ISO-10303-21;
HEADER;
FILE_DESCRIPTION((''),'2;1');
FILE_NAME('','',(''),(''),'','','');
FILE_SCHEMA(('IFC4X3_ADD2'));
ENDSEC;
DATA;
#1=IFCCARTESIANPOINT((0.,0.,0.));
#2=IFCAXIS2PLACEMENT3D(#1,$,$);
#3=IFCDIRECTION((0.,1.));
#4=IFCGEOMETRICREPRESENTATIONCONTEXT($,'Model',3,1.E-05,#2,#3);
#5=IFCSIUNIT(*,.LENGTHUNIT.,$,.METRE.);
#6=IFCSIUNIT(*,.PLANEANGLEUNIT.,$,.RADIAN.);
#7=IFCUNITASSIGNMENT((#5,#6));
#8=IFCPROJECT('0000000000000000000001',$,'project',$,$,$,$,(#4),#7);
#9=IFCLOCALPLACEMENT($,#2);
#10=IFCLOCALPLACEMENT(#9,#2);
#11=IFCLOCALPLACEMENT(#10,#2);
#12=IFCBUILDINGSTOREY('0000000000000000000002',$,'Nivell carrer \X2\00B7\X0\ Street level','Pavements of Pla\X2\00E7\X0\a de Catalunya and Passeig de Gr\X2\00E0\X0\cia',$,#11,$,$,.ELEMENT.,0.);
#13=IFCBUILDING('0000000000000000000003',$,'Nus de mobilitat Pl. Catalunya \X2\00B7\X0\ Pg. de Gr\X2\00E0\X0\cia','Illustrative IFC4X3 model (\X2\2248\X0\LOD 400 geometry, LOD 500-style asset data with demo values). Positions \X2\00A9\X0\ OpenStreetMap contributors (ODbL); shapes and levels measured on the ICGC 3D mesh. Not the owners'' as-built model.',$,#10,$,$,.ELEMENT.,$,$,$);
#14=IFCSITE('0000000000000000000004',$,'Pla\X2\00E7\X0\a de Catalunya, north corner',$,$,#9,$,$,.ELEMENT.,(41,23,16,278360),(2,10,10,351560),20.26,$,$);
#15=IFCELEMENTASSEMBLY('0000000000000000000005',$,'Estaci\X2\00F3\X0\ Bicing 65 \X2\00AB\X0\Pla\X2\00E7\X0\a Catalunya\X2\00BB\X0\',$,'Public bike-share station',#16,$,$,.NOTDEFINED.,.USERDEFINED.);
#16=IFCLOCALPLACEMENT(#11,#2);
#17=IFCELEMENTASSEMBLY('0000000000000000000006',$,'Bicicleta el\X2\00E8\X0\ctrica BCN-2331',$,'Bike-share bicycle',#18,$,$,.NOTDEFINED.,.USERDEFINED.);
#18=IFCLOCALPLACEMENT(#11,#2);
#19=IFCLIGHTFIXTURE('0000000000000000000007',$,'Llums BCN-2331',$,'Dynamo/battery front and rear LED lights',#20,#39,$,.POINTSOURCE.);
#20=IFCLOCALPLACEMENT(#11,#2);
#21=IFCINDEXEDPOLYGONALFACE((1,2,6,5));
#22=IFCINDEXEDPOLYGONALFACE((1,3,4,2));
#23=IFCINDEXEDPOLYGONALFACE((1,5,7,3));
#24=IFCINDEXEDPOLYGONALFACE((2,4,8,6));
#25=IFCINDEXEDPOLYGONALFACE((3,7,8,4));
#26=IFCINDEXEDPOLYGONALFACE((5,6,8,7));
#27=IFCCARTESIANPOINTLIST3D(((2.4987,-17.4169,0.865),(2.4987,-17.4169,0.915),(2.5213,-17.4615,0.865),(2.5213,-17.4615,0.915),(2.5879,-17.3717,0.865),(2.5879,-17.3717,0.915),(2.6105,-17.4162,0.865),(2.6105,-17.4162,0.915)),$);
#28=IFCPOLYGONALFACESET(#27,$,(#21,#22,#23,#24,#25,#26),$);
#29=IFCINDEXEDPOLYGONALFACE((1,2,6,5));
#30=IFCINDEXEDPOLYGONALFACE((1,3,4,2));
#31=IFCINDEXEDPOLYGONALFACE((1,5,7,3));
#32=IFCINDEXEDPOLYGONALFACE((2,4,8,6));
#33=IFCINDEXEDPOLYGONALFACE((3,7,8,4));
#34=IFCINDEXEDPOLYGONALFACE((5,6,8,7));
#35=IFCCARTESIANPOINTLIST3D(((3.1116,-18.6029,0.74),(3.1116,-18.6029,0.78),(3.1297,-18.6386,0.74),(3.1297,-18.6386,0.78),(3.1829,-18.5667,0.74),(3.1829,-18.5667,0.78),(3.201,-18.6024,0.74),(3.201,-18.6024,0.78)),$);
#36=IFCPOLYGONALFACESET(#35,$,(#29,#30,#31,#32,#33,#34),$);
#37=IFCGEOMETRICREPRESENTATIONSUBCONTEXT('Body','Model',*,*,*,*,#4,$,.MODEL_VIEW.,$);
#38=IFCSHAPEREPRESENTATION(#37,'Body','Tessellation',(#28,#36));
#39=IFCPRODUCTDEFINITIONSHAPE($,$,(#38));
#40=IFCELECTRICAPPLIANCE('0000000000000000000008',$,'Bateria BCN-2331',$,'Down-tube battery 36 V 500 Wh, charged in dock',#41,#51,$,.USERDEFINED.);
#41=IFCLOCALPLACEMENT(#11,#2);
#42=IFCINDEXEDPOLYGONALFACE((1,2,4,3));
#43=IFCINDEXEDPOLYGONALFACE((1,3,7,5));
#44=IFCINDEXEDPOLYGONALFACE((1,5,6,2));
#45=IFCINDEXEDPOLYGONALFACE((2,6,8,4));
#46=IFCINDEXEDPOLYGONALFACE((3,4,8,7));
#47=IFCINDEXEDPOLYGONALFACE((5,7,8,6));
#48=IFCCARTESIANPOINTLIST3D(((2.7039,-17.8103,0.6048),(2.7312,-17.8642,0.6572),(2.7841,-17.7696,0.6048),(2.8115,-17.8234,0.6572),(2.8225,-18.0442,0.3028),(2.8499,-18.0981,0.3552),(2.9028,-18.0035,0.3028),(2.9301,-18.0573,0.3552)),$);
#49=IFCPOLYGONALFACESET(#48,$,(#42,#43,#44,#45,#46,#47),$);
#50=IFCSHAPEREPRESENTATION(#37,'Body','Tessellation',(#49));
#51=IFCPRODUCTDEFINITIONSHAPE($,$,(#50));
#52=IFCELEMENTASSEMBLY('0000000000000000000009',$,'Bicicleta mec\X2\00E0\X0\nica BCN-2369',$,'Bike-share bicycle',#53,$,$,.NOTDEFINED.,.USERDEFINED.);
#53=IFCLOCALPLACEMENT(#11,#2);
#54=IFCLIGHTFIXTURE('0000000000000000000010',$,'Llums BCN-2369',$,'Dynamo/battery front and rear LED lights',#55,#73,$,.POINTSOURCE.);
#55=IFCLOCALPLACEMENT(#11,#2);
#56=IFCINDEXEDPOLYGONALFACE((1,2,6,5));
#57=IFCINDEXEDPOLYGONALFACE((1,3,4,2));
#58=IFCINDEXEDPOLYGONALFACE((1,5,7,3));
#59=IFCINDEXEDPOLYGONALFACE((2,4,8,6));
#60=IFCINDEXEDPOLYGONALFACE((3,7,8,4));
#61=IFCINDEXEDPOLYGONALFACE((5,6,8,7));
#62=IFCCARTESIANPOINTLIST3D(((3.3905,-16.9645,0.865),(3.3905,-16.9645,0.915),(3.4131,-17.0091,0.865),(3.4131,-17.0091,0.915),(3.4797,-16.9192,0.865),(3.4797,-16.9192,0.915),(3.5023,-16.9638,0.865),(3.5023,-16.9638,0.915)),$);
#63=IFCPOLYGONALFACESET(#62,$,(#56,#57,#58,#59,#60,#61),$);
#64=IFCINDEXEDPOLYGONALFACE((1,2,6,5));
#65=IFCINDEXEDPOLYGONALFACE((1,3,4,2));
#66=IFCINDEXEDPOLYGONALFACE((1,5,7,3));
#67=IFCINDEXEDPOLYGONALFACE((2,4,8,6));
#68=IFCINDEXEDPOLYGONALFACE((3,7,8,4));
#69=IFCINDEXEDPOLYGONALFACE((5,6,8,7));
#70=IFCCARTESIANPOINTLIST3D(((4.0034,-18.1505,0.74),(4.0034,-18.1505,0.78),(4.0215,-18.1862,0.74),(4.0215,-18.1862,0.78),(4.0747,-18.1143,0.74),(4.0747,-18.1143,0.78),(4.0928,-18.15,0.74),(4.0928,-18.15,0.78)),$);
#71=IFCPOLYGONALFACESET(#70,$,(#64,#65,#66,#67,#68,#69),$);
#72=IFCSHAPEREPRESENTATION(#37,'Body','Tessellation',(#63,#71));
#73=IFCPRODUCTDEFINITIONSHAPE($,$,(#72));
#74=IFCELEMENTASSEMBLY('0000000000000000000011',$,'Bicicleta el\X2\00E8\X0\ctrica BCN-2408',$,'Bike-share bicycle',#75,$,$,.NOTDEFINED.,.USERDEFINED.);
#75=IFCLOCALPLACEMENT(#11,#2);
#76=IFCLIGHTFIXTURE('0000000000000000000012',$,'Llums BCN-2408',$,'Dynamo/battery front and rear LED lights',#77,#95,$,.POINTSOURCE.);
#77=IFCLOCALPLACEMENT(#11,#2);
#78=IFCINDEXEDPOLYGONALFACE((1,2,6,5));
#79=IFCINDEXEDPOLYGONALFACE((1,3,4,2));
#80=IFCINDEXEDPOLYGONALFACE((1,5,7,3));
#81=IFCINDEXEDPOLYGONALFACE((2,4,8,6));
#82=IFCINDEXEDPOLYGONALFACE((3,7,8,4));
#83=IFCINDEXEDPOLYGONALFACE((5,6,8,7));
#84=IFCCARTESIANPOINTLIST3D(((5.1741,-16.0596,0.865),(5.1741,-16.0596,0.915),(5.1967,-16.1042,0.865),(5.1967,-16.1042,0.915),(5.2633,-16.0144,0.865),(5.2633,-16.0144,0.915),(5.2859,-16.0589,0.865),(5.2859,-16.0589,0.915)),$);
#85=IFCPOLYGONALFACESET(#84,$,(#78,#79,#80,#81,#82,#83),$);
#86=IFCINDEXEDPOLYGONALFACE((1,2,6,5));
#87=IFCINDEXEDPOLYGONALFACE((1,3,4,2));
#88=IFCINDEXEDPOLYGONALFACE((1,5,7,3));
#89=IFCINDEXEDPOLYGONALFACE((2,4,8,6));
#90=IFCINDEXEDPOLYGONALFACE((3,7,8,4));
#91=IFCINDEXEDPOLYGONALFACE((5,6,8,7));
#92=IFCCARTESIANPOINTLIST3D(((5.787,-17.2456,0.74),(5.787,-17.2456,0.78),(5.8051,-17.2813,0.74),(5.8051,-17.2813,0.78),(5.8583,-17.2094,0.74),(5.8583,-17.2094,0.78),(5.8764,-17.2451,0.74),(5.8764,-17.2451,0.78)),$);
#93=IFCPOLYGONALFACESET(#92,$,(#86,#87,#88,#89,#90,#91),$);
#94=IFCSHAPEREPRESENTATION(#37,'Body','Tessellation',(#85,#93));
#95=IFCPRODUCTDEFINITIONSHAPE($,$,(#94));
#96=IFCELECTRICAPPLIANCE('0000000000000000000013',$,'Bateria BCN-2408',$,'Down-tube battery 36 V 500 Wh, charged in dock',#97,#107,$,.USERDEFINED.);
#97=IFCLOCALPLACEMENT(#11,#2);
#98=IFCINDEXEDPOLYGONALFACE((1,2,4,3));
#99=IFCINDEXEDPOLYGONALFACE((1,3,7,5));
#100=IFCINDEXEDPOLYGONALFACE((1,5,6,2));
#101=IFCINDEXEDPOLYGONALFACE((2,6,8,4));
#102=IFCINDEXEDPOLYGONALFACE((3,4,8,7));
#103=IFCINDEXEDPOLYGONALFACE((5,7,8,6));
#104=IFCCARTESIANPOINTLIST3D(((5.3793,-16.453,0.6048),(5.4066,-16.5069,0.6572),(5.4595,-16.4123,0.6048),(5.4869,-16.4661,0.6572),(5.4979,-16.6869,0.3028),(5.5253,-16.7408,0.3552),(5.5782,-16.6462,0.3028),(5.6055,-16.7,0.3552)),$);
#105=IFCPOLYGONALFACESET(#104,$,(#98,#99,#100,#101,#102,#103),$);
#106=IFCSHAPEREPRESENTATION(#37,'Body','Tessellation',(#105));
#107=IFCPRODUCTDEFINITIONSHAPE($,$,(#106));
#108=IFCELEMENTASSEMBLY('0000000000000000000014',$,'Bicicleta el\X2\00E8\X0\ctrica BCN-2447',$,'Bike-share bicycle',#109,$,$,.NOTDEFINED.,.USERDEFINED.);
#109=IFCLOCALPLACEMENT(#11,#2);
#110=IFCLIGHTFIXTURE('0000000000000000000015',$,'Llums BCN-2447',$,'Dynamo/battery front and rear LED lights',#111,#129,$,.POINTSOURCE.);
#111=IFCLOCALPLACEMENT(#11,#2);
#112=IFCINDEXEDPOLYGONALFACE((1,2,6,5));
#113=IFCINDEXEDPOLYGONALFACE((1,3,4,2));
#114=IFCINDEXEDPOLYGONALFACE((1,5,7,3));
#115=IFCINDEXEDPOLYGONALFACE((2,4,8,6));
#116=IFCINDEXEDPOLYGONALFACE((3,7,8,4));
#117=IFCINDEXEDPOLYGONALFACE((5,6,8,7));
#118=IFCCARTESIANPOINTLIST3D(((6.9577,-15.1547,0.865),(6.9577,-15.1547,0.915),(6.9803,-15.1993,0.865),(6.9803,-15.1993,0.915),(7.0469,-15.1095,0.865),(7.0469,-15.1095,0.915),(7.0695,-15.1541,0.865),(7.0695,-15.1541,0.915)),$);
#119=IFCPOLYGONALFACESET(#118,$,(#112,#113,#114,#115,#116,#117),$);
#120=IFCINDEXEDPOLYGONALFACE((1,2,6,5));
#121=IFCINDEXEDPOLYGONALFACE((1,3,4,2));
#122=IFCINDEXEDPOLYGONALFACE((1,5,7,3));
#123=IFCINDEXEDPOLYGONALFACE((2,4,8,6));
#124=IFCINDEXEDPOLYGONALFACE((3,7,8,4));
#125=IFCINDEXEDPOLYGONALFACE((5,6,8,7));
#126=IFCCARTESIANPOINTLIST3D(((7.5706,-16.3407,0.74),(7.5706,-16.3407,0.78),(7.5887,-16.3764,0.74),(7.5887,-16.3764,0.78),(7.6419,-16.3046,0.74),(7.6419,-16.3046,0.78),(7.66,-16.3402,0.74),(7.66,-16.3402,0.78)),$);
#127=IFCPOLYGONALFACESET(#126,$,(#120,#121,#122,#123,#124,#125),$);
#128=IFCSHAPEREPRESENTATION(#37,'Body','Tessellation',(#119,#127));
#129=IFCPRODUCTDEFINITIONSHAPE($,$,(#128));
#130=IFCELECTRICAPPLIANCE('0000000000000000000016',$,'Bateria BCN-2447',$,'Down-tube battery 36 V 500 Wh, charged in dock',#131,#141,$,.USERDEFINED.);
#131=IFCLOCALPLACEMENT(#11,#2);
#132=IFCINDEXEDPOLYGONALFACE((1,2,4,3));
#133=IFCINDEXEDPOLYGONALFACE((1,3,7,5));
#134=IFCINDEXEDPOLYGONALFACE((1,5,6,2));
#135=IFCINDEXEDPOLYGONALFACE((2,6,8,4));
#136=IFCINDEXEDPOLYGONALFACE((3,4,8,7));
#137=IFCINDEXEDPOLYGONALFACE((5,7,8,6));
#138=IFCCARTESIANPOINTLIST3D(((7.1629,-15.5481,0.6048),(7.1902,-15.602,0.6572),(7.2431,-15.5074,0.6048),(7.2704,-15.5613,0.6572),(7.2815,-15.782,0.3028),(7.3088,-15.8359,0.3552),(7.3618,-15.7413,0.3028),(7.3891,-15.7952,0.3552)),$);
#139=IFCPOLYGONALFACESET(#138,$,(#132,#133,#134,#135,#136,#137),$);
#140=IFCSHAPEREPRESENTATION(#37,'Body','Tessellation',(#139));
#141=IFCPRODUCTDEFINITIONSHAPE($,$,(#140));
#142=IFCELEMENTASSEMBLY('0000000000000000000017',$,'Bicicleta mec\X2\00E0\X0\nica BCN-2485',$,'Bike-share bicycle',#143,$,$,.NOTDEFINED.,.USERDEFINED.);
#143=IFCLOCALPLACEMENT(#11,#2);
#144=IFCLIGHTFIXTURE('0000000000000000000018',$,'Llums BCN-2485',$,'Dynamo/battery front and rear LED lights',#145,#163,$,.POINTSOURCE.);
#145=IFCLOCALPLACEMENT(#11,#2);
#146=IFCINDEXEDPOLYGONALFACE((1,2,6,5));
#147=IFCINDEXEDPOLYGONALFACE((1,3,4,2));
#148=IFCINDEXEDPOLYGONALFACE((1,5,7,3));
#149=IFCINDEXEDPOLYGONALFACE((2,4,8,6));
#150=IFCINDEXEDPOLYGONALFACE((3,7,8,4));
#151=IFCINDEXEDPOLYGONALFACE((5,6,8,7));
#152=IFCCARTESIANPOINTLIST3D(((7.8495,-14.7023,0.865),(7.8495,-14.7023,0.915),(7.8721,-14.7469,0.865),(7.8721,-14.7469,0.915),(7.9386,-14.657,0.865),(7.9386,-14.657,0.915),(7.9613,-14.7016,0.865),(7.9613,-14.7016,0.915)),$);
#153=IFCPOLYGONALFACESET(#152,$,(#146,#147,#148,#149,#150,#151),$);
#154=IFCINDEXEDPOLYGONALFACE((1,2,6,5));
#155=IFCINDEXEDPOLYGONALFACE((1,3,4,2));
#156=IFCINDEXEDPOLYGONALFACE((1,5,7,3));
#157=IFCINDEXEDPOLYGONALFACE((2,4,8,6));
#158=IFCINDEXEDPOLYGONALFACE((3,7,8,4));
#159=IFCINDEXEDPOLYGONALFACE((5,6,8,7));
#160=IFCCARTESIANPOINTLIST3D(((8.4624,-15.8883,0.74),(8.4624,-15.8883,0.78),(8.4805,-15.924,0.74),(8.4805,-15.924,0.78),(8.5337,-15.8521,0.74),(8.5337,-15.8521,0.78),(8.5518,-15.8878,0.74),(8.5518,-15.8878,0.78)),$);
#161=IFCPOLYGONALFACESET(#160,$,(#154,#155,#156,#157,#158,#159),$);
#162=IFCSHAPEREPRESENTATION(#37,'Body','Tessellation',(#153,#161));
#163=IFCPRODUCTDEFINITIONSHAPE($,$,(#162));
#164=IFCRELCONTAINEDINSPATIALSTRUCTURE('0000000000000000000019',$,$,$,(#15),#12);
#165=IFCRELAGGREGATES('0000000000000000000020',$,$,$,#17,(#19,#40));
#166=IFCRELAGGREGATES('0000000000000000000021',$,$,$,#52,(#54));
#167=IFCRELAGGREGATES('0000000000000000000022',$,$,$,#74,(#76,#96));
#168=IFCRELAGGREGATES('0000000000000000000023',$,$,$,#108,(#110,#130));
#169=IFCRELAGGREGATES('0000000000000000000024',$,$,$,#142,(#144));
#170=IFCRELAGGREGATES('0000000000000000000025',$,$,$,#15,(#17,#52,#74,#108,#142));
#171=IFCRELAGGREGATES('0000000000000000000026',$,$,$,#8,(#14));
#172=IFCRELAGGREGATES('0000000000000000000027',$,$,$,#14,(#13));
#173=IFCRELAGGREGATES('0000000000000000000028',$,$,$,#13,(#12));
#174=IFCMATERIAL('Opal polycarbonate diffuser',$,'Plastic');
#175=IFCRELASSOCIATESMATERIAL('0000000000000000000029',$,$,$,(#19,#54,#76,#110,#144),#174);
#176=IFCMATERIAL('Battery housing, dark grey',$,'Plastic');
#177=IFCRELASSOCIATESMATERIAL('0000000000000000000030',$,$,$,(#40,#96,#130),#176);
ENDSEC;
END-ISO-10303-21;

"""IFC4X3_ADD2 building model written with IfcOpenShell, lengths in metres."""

from ifc_helpers import new_model, si_unit, direction, frame, origin, origin_2d_with_axis, place, context, subcontext, project, spatial, rectangle, extrude, material, element, aggregate, save


model = new_model("IFC4X3_ADD2")

# Units and contexts
model_context = context("Model", 3, precision=1e-05, world=origin(), true_north=direction((0.0, 1.0)))
body_context = subcontext(model_context, "Body", "Model", "MODEL_VIEW")
ifc_project = project(units=[si_unit("LENGTHUNIT", "METRE"), si_unit("PLANEANGLEUNIT", "RADIAN")], contexts=[model_context])

# Site, building, storey
site_placement = place(None, origin())
site = spatial("IfcSite", under=ifc_project, at=site_placement, Name="Plaça de Catalunya, north corner", CompositionType="ELEMENT", RefLatitude=(41, 23, 16, 278360), RefLongitude=(2, 10, 10, 351560), RefElevation=20.26)
building_placement = place(site_placement, origin())
building = spatial("IfcBuilding", under=site, at=building_placement, Name="Nus de mobilitat Pl. Catalunya · Pg. de Gràcia", Description="Illustrative IFC4X3 model (≈LOD 400 geometry, LOD 500-style asset data with demo values). Positions © OpenStreetMap contributors (ODbL); shapes and levels measured on the ICGC 3D mesh. Not the owners' as-built model.", CompositionType="ELEMENT")
storey_placement = place(building_placement, origin())
storey = spatial("IfcBuildingStorey", under=building, at=storey_placement, Name="Nivell carrer · Street level", Description="Pavements of Plaça de Catalunya and Passeig de Gràcia", CompositionType="ELEMENT", Elevation=0.0)

# Element assemblies, light fixtures, electric appliances
assembly_1_placement = place(building_placement, origin())
assembly_1 = element("IfcElementAssembly", 1, at=assembly_1_placement, inside=storey, Name="Estació Bicing 65 «Plaça Catalunya»", ObjectType="Public bike-share station", AssemblyPlace="NOTDEFINED", PredefinedType="USERDEFINED")
assembly_2_placement = place(building_placement, origin())
assembly_2 = element("IfcElementAssembly", 2, at=assembly_2_placement, Name="Bicicleta elèctrica BCN-2331", ObjectType="Bike-share bicycle", AssemblyPlace="NOTDEFINED", PredefinedType="USERDEFINED")
ifc_material_1 = material(Name="Opal polycarbonate diffuser", Category="Plastic")
light_fixture_1_placement = place(building_placement, origin())
light_fixture_1 = element("IfcLightFixture", 3, at=light_fixture_1_placement, material=ifc_material_1, Name="Llums BCN-2331", ObjectType="Dynamo/battery front and rear LED lights", PredefinedType="POINTSOURCE", context=body_context, shape_type="SweptSolid", body=[
    extrude(rectangle(XDim=0.05, YDim=0.1, at=origin_2d_with_axis()), frame((2.5546, -17.4166, 0.915), z_axis=(0.0, 0.0, -1.0), x_axis=(-0.452435, 0.891798, 0.0)), (0.0, 0.0, 1.0), 0.05),
    extrude(rectangle(XDim=0.04, YDim=0.08, at=origin_2d_with_axis()), frame((3.1563, -18.6027, 0.78), z_axis=(0.0, 0.0, -1.0), x_axis=(-0.452435, 0.891798, 0.0)), (0.0, 0.0, 1.0), 0.04),
])
ifc_material_2 = material(Name="Battery housing, dark grey", Category="Plastic")
electric_appliance_1_placement = place(building_placement, origin())
electric_appliance_1 = element("IfcElectricAppliance", 4, at=electric_appliance_1_placement, material=ifc_material_2, Name="Bateria BCN-2331", ObjectType="Down-tube battery 36 V 500 Wh, charged in dock", PredefinedType="USERDEFINED", context=body_context, shape_type="SweptSolid", body=[
    extrude(rectangle(XDim=0.4, YDim=0.09, at=origin_2d_with_axis()), frame((2.8307, -17.9607, 0.5062), z_axis=(-0.341603, 0.673337, -0.655687), x_axis=(-0.296655, 0.58474, 0.755033)), (0.0, 0.0, 1.0), 0.08),
])
aggregate(assembly_2, [light_fixture_1, electric_appliance_1])
assembly_3_placement = place(building_placement, origin())
assembly_3 = element("IfcElementAssembly", 5, at=assembly_3_placement, Name="Bicicleta mecànica BCN-2369", ObjectType="Bike-share bicycle", AssemblyPlace="NOTDEFINED", PredefinedType="USERDEFINED")
light_fixture_2_placement = place(building_placement, origin())
light_fixture_2 = element("IfcLightFixture", 6, at=light_fixture_2_placement, material=ifc_material_1, Name="Llums BCN-2369", ObjectType="Dynamo/battery front and rear LED lights", PredefinedType="POINTSOURCE", context=body_context, shape_type="SweptSolid", body=[
    extrude(rectangle(XDim=0.05, YDim=0.1, at=origin_2d_with_axis()), frame((3.4464, -16.9641, 0.915), z_axis=(0.0, 0.0, -1.0), x_axis=(-0.452435, 0.891798, 0.0)), (0.0, 0.0, 1.0), 0.05),
    extrude(rectangle(XDim=0.04, YDim=0.08, at=origin_2d_with_axis()), frame((4.0481, -18.1502, 0.78), z_axis=(0.0, 0.0, -1.0), x_axis=(-0.452435, 0.891798, 0.0)), (0.0, 0.0, 1.0), 0.04),
])
assembly_4_placement = place(building_placement, origin())
assembly_4 = element("IfcElementAssembly", 7, at=assembly_4_placement, Name="Bicicleta elèctrica BCN-2408", ObjectType="Bike-share bicycle", AssemblyPlace="NOTDEFINED", PredefinedType="USERDEFINED")
light_fixture_3_placement = place(building_placement, origin())
light_fixture_3 = element("IfcLightFixture", 8, at=light_fixture_3_placement, material=ifc_material_1, Name="Llums BCN-2408", ObjectType="Dynamo/battery front and rear LED lights", PredefinedType="POINTSOURCE", context=body_context, shape_type="SweptSolid", body=[
    extrude(rectangle(XDim=0.05, YDim=0.1, at=origin_2d_with_axis()), frame((5.23, -16.0593, 0.915), z_axis=(0.0, 0.0, -1.0), x_axis=(-0.452435, 0.891798, 0.0)), (0.0, 0.0, 1.0), 0.05),
    extrude(rectangle(XDim=0.04, YDim=0.08, at=origin_2d_with_axis()), frame((5.8317, -17.2454, 0.78), z_axis=(0.0, 0.0, -1.0), x_axis=(-0.452435, 0.891798, 0.0)), (0.0, 0.0, 1.0), 0.04),
])
electric_appliance_2_placement = place(building_placement, origin())
electric_appliance_2 = element("IfcElectricAppliance", 9, at=electric_appliance_2_placement, material=ifc_material_2, Name="Bateria BCN-2408", ObjectType="Down-tube battery 36 V 500 Wh, charged in dock", PredefinedType="USERDEFINED", context=body_context, shape_type="SweptSolid", body=[
    extrude(rectangle(XDim=0.4, YDim=0.09, at=origin_2d_with_axis()), frame((5.5061, -16.6034, 0.5062), z_axis=(-0.341603, 0.673337, -0.655687), x_axis=(-0.296655, 0.58474, 0.755033)), (0.0, 0.0, 1.0), 0.08),
])
assembly_5_placement = place(building_placement, origin())
assembly_5 = element("IfcElementAssembly", 10, at=assembly_5_placement, Name="Bicicleta elèctrica BCN-2447", ObjectType="Bike-share bicycle", AssemblyPlace="NOTDEFINED", PredefinedType="USERDEFINED")
light_fixture_4_placement = place(building_placement, origin())
light_fixture_4 = element("IfcLightFixture", 11, at=light_fixture_4_placement, material=ifc_material_1, Name="Llums BCN-2447", ObjectType="Dynamo/battery front and rear LED lights", PredefinedType="POINTSOURCE", context=body_context, shape_type="SweptSolid", body=[
    extrude(rectangle(XDim=0.05, YDim=0.1, at=origin_2d_with_axis()), frame((7.0136, -15.1544, 0.915), z_axis=(0.0, 0.0, -1.0), x_axis=(-0.452435, 0.891798, 0.0)), (0.0, 0.0, 1.0), 0.05),
    extrude(rectangle(XDim=0.04, YDim=0.08, at=origin_2d_with_axis()), frame((7.6153, -16.3405, 0.78), z_axis=(0.0, 0.0, -1.0), x_axis=(-0.452435, 0.891798, 0.0)), (0.0, 0.0, 1.0), 0.04),
])
electric_appliance_3_placement = place(building_placement, origin())
electric_appliance_3 = element("IfcElectricAppliance", 12, at=electric_appliance_3_placement, material=ifc_material_2, Name="Bateria BCN-2447", ObjectType="Down-tube battery 36 V 500 Wh, charged in dock", PredefinedType="USERDEFINED", context=body_context, shape_type="SweptSolid", body=[
    extrude(rectangle(XDim=0.4, YDim=0.09, at=origin_2d_with_axis()), frame((7.2896, -15.6986, 0.5062), z_axis=(-0.341603, 0.673337, -0.655687), x_axis=(-0.296655, 0.58474, 0.755033)), (0.0, 0.0, 1.0), 0.08),
])
assembly_6_placement = place(building_placement, origin())
assembly_6 = element("IfcElementAssembly", 13, at=assembly_6_placement, Name="Bicicleta mecànica BCN-2485", ObjectType="Bike-share bicycle", AssemblyPlace="NOTDEFINED", PredefinedType="USERDEFINED")
light_fixture_5_placement = place(building_placement, origin())
light_fixture_5 = element("IfcLightFixture", 14, at=light_fixture_5_placement, material=ifc_material_1, Name="Llums BCN-2485", ObjectType="Dynamo/battery front and rear LED lights", PredefinedType="POINTSOURCE", context=body_context, shape_type="SweptSolid", body=[
    extrude(rectangle(XDim=0.05, YDim=0.1, at=origin_2d_with_axis()), frame((7.9054, -14.702, 0.915), z_axis=(0.0, 0.0, -1.0), x_axis=(-0.452435, 0.891798, 0.0)), (0.0, 0.0, 1.0), 0.05),
    extrude(rectangle(XDim=0.04, YDim=0.08, at=origin_2d_with_axis()), frame((8.5071, -15.8881, 0.78), z_axis=(0.0, 0.0, -1.0), x_axis=(-0.452435, 0.891798, 0.0)), (0.0, 0.0, 1.0), 0.04),
])
aggregate(assembly_3, [light_fixture_2])
aggregate(assembly_4, [light_fixture_3, electric_appliance_2])
aggregate(assembly_5, [light_fixture_4, electric_appliance_3])
aggregate(assembly_6, [light_fixture_5])
aggregate(assembly_1, [assembly_2, assembly_3, assembly_4, assembly_5, assembly_6])

save(model, "model.ifc")
